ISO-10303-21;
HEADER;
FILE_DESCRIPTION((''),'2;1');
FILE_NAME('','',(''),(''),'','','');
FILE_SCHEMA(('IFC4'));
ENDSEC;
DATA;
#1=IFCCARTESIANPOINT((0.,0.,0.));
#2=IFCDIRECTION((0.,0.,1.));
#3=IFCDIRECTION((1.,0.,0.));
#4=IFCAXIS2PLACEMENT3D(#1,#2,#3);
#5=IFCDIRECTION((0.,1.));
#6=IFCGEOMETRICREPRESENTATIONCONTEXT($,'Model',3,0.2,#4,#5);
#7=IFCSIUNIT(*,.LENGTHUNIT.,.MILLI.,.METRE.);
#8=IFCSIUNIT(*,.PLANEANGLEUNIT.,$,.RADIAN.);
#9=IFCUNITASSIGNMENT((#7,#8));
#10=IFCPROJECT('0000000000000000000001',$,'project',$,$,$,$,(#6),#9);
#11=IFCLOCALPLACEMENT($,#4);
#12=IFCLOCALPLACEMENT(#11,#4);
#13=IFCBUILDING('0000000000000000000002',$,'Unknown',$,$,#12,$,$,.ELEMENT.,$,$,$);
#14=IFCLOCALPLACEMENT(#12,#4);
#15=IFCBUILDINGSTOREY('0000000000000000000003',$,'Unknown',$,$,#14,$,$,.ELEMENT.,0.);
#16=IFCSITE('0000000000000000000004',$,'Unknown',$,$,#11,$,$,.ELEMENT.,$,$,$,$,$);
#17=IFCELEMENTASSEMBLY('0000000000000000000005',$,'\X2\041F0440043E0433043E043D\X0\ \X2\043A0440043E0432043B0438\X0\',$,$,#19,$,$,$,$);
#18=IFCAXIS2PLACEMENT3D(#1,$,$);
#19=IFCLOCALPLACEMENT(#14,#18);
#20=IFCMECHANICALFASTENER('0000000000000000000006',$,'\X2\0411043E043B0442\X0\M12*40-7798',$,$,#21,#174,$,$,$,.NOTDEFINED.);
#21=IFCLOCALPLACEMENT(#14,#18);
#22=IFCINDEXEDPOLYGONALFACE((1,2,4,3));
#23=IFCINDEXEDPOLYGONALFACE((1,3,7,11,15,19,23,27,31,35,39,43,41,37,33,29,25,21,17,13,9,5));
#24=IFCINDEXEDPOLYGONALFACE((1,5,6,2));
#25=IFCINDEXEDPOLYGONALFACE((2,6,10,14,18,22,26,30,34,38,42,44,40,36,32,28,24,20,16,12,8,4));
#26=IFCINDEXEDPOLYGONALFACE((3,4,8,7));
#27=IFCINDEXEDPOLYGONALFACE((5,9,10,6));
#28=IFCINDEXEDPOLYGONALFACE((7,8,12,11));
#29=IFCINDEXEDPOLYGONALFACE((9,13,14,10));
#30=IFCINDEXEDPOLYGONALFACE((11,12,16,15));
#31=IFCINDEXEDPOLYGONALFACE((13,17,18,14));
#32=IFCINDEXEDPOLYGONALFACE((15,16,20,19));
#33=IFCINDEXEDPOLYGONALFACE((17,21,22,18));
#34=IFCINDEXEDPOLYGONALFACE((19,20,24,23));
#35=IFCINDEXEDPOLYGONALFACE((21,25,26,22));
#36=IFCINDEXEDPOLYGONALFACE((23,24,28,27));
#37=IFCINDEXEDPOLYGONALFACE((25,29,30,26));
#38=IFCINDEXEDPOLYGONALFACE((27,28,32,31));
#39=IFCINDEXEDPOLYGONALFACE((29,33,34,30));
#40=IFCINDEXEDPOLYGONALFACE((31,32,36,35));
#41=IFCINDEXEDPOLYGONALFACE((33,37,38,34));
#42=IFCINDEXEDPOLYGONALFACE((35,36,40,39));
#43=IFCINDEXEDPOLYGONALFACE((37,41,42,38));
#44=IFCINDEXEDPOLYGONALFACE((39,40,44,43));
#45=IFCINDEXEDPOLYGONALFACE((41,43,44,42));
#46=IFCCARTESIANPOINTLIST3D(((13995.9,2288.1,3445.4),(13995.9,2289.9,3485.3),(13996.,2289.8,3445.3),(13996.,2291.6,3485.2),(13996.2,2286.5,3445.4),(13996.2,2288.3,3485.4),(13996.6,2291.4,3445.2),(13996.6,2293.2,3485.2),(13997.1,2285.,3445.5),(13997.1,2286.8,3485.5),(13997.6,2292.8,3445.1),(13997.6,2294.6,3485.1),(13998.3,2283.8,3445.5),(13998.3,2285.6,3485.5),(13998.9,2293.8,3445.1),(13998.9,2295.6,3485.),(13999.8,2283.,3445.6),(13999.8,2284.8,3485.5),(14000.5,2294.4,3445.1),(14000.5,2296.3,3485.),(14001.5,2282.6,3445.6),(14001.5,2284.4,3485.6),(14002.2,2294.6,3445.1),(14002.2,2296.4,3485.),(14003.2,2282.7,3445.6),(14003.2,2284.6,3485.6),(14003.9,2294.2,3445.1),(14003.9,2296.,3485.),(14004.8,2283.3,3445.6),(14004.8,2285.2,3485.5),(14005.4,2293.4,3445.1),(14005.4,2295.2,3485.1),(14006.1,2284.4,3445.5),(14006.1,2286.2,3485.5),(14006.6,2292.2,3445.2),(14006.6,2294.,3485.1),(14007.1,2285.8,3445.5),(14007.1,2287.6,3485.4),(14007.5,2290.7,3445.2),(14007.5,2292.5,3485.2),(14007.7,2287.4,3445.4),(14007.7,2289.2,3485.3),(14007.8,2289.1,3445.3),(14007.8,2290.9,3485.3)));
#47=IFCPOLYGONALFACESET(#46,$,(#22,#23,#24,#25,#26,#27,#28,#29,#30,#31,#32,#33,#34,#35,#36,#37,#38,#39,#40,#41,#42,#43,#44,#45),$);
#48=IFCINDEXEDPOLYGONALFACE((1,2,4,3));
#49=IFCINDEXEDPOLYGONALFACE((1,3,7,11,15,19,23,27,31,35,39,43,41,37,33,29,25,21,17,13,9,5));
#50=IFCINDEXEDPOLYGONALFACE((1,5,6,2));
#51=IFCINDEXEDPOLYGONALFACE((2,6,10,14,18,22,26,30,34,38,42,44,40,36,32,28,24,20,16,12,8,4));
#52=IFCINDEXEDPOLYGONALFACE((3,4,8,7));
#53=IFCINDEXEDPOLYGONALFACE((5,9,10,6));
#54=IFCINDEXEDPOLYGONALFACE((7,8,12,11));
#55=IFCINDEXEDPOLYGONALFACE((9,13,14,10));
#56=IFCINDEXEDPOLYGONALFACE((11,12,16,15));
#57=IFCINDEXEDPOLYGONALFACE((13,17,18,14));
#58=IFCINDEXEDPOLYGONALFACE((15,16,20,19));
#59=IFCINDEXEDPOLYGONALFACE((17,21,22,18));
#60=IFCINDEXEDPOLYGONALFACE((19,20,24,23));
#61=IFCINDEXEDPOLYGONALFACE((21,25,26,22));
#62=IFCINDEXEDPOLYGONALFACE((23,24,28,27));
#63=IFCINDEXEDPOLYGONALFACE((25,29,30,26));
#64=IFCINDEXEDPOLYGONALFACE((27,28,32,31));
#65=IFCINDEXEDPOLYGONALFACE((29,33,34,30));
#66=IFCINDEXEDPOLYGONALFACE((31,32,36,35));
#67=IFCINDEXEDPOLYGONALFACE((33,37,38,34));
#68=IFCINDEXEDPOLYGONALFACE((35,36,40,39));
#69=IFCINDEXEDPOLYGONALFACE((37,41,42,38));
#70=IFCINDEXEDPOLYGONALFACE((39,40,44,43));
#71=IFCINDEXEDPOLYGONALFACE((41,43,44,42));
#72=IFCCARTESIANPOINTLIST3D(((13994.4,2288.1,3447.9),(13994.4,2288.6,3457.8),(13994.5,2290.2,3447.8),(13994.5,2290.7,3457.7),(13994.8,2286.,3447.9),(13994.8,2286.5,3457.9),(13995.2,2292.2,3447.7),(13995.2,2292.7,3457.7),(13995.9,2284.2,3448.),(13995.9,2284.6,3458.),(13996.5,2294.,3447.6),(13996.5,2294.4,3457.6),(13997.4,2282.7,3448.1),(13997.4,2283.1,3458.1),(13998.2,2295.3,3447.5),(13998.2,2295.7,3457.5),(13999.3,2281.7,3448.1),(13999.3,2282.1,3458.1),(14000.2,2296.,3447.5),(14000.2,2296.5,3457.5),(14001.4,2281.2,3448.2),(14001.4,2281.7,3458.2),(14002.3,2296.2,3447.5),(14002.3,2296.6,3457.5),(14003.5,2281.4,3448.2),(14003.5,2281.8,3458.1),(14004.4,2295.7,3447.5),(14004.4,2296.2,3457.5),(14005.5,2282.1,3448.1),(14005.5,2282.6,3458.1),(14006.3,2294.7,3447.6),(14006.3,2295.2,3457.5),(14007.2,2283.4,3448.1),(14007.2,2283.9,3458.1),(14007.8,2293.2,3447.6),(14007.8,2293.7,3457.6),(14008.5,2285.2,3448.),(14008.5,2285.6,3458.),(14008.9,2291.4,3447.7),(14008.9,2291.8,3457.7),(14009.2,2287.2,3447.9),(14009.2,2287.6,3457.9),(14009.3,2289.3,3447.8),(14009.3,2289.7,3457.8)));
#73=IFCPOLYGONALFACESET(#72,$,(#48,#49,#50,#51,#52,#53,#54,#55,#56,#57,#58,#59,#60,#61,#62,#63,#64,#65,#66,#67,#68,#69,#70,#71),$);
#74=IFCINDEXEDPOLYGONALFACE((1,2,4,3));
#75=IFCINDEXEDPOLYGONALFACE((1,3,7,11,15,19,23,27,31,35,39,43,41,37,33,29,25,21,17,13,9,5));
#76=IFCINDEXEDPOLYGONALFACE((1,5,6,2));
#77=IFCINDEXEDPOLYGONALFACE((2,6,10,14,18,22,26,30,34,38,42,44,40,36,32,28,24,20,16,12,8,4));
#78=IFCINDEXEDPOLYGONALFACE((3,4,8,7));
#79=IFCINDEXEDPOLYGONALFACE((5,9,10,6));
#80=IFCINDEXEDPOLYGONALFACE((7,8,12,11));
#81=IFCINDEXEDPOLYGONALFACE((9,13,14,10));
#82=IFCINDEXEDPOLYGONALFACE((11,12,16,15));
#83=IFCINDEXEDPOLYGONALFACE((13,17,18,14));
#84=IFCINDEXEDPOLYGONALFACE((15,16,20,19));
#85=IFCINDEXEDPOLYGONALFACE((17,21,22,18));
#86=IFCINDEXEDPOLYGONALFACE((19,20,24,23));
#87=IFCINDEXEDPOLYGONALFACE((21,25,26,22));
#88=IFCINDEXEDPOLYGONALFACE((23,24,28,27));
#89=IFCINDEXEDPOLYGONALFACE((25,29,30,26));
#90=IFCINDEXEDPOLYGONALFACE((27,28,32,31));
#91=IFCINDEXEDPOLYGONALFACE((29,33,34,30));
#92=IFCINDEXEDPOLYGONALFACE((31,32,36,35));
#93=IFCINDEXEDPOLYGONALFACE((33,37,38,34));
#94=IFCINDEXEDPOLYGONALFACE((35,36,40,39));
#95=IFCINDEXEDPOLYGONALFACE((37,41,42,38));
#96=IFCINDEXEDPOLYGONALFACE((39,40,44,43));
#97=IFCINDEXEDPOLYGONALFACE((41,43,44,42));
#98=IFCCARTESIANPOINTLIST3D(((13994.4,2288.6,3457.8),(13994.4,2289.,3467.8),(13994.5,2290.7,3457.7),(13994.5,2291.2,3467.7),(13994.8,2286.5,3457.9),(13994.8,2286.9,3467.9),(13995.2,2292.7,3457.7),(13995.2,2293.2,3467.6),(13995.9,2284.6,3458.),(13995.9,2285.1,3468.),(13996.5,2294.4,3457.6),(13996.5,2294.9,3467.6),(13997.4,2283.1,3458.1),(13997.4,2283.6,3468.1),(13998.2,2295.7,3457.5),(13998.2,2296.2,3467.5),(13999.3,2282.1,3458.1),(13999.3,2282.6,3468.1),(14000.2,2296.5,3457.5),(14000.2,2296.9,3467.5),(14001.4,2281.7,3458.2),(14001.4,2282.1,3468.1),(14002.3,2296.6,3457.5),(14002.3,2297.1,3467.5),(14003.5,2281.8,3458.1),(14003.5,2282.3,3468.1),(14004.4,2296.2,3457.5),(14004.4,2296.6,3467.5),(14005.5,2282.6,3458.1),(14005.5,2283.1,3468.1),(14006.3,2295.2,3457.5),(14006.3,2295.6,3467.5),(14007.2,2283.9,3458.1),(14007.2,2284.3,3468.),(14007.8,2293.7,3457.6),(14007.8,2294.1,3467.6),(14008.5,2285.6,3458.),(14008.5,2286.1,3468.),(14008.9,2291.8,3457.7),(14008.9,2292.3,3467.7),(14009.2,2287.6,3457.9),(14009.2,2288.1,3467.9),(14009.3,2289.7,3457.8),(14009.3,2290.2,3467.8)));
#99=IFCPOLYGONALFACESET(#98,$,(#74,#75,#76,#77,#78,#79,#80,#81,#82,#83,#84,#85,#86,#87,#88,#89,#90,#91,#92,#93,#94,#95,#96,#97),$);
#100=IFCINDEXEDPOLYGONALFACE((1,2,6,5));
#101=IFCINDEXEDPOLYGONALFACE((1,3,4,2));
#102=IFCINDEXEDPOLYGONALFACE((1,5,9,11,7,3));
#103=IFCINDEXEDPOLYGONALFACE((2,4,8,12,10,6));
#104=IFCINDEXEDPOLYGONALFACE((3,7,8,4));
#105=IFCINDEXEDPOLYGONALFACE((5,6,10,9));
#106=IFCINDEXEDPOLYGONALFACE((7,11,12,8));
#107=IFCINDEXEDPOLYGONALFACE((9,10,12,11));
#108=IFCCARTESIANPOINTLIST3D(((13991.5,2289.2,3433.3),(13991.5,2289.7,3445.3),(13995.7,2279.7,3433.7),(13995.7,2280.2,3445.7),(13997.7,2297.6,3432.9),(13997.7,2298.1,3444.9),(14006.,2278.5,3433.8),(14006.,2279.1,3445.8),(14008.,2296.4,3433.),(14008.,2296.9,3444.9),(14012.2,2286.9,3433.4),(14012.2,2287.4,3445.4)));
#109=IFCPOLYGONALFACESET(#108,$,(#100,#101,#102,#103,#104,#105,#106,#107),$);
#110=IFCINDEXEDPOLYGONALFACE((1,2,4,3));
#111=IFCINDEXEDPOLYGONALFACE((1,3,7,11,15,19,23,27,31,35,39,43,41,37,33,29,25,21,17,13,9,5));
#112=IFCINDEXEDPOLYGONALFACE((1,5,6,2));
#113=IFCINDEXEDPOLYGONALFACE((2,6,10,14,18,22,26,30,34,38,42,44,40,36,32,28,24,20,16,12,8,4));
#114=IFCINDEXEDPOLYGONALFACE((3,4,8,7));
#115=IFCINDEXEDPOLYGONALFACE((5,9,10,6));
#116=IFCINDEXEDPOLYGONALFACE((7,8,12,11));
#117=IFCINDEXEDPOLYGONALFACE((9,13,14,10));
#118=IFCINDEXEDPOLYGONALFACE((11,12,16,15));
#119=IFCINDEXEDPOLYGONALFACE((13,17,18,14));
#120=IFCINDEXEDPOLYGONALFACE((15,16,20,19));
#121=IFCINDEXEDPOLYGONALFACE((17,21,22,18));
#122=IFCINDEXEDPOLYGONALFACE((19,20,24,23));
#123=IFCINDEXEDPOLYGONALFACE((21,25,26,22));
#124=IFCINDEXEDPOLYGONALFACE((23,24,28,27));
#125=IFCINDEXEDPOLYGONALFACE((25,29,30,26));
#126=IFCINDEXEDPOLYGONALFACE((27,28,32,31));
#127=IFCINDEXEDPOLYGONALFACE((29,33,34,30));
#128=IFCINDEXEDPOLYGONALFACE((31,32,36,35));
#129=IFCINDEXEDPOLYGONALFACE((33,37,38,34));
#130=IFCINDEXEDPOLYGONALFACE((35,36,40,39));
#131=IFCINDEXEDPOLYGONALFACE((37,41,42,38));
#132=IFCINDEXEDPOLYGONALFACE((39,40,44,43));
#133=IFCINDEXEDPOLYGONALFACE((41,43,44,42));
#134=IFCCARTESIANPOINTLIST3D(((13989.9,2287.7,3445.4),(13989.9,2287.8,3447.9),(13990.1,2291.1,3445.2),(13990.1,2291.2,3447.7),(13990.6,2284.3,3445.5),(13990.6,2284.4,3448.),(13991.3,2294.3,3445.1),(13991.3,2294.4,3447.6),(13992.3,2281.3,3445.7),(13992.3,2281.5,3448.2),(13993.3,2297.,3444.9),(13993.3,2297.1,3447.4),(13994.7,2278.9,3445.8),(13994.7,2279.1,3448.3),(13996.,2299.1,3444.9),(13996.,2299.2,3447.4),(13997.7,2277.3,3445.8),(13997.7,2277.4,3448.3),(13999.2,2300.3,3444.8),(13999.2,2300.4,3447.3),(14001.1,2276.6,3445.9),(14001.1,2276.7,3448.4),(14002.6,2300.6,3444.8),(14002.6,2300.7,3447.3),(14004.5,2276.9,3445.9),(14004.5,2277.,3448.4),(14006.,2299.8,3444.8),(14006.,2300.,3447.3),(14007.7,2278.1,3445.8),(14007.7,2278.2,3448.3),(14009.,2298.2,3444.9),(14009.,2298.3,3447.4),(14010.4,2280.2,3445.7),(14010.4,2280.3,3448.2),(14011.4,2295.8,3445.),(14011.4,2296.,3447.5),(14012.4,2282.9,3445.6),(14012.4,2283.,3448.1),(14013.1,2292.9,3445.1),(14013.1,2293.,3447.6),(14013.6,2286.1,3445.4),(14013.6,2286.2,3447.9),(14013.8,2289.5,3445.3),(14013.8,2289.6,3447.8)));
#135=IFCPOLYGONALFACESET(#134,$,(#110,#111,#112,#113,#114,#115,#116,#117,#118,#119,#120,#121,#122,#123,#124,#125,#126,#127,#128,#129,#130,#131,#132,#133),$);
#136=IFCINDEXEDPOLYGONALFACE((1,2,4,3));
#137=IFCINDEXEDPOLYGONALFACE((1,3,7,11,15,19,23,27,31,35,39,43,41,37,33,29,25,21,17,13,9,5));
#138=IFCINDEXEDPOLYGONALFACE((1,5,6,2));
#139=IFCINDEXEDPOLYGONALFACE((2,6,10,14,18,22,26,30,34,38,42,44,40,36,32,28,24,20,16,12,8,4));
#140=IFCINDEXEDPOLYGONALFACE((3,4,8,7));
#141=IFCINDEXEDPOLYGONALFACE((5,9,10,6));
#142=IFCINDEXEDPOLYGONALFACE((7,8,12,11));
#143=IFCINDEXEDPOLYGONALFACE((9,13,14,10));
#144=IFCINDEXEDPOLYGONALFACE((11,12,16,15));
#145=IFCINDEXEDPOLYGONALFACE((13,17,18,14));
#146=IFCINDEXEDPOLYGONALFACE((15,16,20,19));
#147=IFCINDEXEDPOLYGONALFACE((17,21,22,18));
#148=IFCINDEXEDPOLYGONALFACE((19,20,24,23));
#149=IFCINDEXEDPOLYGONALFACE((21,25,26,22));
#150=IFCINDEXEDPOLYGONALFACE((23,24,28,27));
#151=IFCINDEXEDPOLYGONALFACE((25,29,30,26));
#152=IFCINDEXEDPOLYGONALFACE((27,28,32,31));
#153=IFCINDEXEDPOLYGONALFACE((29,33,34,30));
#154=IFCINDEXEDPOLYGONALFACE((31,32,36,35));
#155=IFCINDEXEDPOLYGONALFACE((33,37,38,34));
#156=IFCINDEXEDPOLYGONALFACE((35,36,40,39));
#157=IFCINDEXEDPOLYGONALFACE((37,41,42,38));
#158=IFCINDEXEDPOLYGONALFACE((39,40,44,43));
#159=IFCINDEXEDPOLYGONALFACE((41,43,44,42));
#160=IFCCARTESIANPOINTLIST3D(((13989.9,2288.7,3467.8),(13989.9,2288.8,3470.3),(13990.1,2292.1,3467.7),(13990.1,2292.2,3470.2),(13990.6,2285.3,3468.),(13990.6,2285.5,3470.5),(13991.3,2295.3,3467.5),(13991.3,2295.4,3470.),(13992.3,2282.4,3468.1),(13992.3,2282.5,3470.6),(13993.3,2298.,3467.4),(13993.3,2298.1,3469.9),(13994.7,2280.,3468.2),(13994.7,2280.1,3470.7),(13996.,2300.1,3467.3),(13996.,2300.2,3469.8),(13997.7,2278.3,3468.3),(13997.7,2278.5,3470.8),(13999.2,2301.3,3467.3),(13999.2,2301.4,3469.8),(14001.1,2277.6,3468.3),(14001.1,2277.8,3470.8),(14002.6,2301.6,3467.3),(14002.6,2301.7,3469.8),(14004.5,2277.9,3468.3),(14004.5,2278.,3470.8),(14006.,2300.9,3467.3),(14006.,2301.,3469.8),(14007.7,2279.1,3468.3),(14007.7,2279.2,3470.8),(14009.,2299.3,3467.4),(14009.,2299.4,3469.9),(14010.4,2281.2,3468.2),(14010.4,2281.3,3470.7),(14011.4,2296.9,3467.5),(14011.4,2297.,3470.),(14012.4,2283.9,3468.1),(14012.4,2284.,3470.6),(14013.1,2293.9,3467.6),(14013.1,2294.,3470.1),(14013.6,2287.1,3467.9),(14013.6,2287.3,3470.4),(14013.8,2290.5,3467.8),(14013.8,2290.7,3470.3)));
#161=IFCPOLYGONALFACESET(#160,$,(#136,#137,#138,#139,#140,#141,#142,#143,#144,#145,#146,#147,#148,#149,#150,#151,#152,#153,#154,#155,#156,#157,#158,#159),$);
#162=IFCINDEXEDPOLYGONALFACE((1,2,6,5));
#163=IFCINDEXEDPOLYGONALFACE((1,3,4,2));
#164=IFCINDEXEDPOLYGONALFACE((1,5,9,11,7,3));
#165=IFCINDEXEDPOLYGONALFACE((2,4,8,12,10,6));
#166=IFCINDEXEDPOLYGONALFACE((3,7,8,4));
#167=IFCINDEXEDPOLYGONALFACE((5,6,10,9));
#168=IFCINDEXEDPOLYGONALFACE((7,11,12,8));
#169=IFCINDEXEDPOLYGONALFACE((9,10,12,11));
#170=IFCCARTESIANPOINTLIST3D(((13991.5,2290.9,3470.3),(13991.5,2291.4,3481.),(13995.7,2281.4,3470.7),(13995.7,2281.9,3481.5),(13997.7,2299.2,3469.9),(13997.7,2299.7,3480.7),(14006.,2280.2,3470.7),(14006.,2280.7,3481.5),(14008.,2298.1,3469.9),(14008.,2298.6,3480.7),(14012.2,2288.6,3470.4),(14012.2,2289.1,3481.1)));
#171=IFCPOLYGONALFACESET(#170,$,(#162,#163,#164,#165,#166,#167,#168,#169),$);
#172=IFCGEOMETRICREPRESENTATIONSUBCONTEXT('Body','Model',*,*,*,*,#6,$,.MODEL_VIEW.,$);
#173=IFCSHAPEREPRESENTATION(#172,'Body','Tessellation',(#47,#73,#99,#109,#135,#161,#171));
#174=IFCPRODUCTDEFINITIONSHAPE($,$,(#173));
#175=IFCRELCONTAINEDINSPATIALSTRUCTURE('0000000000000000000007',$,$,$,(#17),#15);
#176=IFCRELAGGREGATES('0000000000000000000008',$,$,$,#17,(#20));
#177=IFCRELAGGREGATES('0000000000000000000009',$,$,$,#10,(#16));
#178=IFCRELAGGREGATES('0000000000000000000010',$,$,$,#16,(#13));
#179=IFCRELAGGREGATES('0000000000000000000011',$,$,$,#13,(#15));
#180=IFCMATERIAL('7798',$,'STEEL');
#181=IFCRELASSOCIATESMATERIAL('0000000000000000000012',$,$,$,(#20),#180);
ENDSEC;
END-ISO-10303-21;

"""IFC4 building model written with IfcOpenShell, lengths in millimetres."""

from ifc_helpers import new_model, si_unit, direction, frame, origin_with_axes, place, context, subcontext, project, spatial, line, arc, indexed_curve, outline, extrude, source, transform, mapped, material, element, aggregate, save


model = new_model("IFC4")

# Units and contexts
model_context = context("Model", 3, precision=0.2, world=origin_with_axes(), true_north=direction((0.0, 1.0)))
body_context = subcontext(model_context, "Body", "Model", "MODEL_VIEW")
ifc_project = project(units=[si_unit("LENGTHUNIT", "METRE", prefix="MILLI"), si_unit("PLANEANGLEUNIT", "RADIAN")], contexts=[model_context])

# Site, building, storey
site_placement = place(None, origin_with_axes())
site = spatial("IfcSite", under=ifc_project, at=site_placement, Name="Unknown", CompositionType="ELEMENT")
building_placement = place(site_placement, origin_with_axes())
building = spatial("IfcBuilding", under=site, at=building_placement, Name="Unknown", CompositionType="ELEMENT")
storey_placement = place(building_placement, origin_with_axes())
storey = spatial("IfcBuildingStorey", under=building, at=storey_placement, Name="Unknown", CompositionType="ELEMENT", Elevation=0.0)

# Element assembly
assembly_1_placement = place(storey_placement, frame((17395.0, 2187.1, 3457.5), z_axis=(0.0, 0.998969, -0.045408), x_axis=(-1.0, 0.0, 0.0)))
assembly_1 = element("IfcElementAssembly", 1, at=assembly_1_placement, inside=storey, Name="Прогон кровли")

# Mechanical fastener
ifc_material_1 = material(Name="7798", Category="STEEL")
shared_shape_1 = source(origin_with_axes(), body_context, "Body", "SweptSolid", [
    extrude(outline(indexed_curve([(6.0, 0.0), (0.0, 6.0), (-6.0, 0.0), (0.0, -6.0)], segments=[arc(1, 2, 3), arc(3, 4, 1)])), frame((0.0, 0.0, 2.5), z_axis=(0.0, 0.0, -1.0), x_axis=(0.0, 1.0, 0.0)), (0.0, 0.0, 1.0), 40.0),
    extrude(outline(indexed_curve([(7.5, 0.0), (0.0, 7.5), (-7.5, 0.0), (0.0, -7.5)], segments=[arc(1, 2, 3), arc(3, 4, 1)])), frame((0.0, 0.0, 0.0), z_axis=(0.0, 0.0, -1.0), x_axis=(0.0, 1.0, 0.0)), (0.0, 0.0, 1.0), 10.0),
    extrude(outline(indexed_curve([(7.5, 0.0), (0.0, 7.5), (-7.5, 0.0), (0.0, -7.5)], segments=[arc(1, 2, 3), arc(3, 4, 1)])), frame((0.0, 0.0, -10.0), z_axis=(0.0, 0.0, -1.0), x_axis=(0.0, 1.0, 0.0)), (0.0, 0.0, 1.0), 10.0),
    extrude(outline(indexed_curve([(10.4, 0.0), (5.2, 9.0), (-5.2, 9.0), (-10.4, 0.0), (-5.2, -9.0), (5.2, -9.0)], segments=[line(1, 2, 3, 4, 5, 6, 1)])), frame((0.0, 0.0, 14.5), z_axis=(0.0, 0.0, -1.0), x_axis=(0.0, 1.0, 0.0)), (0.0, 0.0, 1.0), 12.0),
    extrude(outline(indexed_curve([(12.0, 0.0), (0.0, 12.0), (-12.0, 0.0), (0.0, -12.0)], segments=[arc(1, 2, 3), arc(3, 4, 1)])), frame((0.0, 0.0, 2.5), z_axis=(0.0, 0.0, -1.0), x_axis=(0.0, 1.0, 0.0)), (0.0, 0.0, 1.0), 2.5),
    extrude(outline(indexed_curve([(12.0, 0.0), (0.0, 12.0), (-12.0, 0.0), (0.0, -12.0)], segments=[arc(1, 2, 3), arc(3, 4, 1)])), frame((0.0, 0.0, -20.0), z_axis=(0.0, 0.0, -1.0), x_axis=(0.0, 1.0, 0.0)), (0.0, 0.0, 1.0), 2.5),
    extrude(outline(indexed_curve([(10.4, 0.0), (5.2, 9.0), (-5.2, 9.0), (-10.4, 0.0), (-5.2, -9.0), (5.2, -9.0)], segments=[line(1, 2, 3, 4, 5, 6, 1)])), frame((0.0, 0.0, -22.5), z_axis=(0.0, 0.0, -1.0), x_axis=(0.0, 1.0, 0.0)), (0.0, 0.0, 1.0), 10.8),
])
mechanical_fastener_1_placement = place(assembly_1_placement, frame((3393.1, -5.0, 102.0), z_axis=(0.0, -1.0, 0.0), x_axis=(0.804616, 0.0, 0.593795)))
mechanical_fastener_1 = element("IfcMechanicalFastener", 2, at=mechanical_fastener_1_placement, material=ifc_material_1, Name="БолтM12*40-7798", PredefinedType="NOTDEFINED", context=body_context, shape_type="MappedRepresentation", body=[
    mapped(shared_shape_1, transform((0.0, 0.0, 0.0))),
])
aggregate(assembly_1, [mechanical_fastener_1])

save(model, "model.ifc")
